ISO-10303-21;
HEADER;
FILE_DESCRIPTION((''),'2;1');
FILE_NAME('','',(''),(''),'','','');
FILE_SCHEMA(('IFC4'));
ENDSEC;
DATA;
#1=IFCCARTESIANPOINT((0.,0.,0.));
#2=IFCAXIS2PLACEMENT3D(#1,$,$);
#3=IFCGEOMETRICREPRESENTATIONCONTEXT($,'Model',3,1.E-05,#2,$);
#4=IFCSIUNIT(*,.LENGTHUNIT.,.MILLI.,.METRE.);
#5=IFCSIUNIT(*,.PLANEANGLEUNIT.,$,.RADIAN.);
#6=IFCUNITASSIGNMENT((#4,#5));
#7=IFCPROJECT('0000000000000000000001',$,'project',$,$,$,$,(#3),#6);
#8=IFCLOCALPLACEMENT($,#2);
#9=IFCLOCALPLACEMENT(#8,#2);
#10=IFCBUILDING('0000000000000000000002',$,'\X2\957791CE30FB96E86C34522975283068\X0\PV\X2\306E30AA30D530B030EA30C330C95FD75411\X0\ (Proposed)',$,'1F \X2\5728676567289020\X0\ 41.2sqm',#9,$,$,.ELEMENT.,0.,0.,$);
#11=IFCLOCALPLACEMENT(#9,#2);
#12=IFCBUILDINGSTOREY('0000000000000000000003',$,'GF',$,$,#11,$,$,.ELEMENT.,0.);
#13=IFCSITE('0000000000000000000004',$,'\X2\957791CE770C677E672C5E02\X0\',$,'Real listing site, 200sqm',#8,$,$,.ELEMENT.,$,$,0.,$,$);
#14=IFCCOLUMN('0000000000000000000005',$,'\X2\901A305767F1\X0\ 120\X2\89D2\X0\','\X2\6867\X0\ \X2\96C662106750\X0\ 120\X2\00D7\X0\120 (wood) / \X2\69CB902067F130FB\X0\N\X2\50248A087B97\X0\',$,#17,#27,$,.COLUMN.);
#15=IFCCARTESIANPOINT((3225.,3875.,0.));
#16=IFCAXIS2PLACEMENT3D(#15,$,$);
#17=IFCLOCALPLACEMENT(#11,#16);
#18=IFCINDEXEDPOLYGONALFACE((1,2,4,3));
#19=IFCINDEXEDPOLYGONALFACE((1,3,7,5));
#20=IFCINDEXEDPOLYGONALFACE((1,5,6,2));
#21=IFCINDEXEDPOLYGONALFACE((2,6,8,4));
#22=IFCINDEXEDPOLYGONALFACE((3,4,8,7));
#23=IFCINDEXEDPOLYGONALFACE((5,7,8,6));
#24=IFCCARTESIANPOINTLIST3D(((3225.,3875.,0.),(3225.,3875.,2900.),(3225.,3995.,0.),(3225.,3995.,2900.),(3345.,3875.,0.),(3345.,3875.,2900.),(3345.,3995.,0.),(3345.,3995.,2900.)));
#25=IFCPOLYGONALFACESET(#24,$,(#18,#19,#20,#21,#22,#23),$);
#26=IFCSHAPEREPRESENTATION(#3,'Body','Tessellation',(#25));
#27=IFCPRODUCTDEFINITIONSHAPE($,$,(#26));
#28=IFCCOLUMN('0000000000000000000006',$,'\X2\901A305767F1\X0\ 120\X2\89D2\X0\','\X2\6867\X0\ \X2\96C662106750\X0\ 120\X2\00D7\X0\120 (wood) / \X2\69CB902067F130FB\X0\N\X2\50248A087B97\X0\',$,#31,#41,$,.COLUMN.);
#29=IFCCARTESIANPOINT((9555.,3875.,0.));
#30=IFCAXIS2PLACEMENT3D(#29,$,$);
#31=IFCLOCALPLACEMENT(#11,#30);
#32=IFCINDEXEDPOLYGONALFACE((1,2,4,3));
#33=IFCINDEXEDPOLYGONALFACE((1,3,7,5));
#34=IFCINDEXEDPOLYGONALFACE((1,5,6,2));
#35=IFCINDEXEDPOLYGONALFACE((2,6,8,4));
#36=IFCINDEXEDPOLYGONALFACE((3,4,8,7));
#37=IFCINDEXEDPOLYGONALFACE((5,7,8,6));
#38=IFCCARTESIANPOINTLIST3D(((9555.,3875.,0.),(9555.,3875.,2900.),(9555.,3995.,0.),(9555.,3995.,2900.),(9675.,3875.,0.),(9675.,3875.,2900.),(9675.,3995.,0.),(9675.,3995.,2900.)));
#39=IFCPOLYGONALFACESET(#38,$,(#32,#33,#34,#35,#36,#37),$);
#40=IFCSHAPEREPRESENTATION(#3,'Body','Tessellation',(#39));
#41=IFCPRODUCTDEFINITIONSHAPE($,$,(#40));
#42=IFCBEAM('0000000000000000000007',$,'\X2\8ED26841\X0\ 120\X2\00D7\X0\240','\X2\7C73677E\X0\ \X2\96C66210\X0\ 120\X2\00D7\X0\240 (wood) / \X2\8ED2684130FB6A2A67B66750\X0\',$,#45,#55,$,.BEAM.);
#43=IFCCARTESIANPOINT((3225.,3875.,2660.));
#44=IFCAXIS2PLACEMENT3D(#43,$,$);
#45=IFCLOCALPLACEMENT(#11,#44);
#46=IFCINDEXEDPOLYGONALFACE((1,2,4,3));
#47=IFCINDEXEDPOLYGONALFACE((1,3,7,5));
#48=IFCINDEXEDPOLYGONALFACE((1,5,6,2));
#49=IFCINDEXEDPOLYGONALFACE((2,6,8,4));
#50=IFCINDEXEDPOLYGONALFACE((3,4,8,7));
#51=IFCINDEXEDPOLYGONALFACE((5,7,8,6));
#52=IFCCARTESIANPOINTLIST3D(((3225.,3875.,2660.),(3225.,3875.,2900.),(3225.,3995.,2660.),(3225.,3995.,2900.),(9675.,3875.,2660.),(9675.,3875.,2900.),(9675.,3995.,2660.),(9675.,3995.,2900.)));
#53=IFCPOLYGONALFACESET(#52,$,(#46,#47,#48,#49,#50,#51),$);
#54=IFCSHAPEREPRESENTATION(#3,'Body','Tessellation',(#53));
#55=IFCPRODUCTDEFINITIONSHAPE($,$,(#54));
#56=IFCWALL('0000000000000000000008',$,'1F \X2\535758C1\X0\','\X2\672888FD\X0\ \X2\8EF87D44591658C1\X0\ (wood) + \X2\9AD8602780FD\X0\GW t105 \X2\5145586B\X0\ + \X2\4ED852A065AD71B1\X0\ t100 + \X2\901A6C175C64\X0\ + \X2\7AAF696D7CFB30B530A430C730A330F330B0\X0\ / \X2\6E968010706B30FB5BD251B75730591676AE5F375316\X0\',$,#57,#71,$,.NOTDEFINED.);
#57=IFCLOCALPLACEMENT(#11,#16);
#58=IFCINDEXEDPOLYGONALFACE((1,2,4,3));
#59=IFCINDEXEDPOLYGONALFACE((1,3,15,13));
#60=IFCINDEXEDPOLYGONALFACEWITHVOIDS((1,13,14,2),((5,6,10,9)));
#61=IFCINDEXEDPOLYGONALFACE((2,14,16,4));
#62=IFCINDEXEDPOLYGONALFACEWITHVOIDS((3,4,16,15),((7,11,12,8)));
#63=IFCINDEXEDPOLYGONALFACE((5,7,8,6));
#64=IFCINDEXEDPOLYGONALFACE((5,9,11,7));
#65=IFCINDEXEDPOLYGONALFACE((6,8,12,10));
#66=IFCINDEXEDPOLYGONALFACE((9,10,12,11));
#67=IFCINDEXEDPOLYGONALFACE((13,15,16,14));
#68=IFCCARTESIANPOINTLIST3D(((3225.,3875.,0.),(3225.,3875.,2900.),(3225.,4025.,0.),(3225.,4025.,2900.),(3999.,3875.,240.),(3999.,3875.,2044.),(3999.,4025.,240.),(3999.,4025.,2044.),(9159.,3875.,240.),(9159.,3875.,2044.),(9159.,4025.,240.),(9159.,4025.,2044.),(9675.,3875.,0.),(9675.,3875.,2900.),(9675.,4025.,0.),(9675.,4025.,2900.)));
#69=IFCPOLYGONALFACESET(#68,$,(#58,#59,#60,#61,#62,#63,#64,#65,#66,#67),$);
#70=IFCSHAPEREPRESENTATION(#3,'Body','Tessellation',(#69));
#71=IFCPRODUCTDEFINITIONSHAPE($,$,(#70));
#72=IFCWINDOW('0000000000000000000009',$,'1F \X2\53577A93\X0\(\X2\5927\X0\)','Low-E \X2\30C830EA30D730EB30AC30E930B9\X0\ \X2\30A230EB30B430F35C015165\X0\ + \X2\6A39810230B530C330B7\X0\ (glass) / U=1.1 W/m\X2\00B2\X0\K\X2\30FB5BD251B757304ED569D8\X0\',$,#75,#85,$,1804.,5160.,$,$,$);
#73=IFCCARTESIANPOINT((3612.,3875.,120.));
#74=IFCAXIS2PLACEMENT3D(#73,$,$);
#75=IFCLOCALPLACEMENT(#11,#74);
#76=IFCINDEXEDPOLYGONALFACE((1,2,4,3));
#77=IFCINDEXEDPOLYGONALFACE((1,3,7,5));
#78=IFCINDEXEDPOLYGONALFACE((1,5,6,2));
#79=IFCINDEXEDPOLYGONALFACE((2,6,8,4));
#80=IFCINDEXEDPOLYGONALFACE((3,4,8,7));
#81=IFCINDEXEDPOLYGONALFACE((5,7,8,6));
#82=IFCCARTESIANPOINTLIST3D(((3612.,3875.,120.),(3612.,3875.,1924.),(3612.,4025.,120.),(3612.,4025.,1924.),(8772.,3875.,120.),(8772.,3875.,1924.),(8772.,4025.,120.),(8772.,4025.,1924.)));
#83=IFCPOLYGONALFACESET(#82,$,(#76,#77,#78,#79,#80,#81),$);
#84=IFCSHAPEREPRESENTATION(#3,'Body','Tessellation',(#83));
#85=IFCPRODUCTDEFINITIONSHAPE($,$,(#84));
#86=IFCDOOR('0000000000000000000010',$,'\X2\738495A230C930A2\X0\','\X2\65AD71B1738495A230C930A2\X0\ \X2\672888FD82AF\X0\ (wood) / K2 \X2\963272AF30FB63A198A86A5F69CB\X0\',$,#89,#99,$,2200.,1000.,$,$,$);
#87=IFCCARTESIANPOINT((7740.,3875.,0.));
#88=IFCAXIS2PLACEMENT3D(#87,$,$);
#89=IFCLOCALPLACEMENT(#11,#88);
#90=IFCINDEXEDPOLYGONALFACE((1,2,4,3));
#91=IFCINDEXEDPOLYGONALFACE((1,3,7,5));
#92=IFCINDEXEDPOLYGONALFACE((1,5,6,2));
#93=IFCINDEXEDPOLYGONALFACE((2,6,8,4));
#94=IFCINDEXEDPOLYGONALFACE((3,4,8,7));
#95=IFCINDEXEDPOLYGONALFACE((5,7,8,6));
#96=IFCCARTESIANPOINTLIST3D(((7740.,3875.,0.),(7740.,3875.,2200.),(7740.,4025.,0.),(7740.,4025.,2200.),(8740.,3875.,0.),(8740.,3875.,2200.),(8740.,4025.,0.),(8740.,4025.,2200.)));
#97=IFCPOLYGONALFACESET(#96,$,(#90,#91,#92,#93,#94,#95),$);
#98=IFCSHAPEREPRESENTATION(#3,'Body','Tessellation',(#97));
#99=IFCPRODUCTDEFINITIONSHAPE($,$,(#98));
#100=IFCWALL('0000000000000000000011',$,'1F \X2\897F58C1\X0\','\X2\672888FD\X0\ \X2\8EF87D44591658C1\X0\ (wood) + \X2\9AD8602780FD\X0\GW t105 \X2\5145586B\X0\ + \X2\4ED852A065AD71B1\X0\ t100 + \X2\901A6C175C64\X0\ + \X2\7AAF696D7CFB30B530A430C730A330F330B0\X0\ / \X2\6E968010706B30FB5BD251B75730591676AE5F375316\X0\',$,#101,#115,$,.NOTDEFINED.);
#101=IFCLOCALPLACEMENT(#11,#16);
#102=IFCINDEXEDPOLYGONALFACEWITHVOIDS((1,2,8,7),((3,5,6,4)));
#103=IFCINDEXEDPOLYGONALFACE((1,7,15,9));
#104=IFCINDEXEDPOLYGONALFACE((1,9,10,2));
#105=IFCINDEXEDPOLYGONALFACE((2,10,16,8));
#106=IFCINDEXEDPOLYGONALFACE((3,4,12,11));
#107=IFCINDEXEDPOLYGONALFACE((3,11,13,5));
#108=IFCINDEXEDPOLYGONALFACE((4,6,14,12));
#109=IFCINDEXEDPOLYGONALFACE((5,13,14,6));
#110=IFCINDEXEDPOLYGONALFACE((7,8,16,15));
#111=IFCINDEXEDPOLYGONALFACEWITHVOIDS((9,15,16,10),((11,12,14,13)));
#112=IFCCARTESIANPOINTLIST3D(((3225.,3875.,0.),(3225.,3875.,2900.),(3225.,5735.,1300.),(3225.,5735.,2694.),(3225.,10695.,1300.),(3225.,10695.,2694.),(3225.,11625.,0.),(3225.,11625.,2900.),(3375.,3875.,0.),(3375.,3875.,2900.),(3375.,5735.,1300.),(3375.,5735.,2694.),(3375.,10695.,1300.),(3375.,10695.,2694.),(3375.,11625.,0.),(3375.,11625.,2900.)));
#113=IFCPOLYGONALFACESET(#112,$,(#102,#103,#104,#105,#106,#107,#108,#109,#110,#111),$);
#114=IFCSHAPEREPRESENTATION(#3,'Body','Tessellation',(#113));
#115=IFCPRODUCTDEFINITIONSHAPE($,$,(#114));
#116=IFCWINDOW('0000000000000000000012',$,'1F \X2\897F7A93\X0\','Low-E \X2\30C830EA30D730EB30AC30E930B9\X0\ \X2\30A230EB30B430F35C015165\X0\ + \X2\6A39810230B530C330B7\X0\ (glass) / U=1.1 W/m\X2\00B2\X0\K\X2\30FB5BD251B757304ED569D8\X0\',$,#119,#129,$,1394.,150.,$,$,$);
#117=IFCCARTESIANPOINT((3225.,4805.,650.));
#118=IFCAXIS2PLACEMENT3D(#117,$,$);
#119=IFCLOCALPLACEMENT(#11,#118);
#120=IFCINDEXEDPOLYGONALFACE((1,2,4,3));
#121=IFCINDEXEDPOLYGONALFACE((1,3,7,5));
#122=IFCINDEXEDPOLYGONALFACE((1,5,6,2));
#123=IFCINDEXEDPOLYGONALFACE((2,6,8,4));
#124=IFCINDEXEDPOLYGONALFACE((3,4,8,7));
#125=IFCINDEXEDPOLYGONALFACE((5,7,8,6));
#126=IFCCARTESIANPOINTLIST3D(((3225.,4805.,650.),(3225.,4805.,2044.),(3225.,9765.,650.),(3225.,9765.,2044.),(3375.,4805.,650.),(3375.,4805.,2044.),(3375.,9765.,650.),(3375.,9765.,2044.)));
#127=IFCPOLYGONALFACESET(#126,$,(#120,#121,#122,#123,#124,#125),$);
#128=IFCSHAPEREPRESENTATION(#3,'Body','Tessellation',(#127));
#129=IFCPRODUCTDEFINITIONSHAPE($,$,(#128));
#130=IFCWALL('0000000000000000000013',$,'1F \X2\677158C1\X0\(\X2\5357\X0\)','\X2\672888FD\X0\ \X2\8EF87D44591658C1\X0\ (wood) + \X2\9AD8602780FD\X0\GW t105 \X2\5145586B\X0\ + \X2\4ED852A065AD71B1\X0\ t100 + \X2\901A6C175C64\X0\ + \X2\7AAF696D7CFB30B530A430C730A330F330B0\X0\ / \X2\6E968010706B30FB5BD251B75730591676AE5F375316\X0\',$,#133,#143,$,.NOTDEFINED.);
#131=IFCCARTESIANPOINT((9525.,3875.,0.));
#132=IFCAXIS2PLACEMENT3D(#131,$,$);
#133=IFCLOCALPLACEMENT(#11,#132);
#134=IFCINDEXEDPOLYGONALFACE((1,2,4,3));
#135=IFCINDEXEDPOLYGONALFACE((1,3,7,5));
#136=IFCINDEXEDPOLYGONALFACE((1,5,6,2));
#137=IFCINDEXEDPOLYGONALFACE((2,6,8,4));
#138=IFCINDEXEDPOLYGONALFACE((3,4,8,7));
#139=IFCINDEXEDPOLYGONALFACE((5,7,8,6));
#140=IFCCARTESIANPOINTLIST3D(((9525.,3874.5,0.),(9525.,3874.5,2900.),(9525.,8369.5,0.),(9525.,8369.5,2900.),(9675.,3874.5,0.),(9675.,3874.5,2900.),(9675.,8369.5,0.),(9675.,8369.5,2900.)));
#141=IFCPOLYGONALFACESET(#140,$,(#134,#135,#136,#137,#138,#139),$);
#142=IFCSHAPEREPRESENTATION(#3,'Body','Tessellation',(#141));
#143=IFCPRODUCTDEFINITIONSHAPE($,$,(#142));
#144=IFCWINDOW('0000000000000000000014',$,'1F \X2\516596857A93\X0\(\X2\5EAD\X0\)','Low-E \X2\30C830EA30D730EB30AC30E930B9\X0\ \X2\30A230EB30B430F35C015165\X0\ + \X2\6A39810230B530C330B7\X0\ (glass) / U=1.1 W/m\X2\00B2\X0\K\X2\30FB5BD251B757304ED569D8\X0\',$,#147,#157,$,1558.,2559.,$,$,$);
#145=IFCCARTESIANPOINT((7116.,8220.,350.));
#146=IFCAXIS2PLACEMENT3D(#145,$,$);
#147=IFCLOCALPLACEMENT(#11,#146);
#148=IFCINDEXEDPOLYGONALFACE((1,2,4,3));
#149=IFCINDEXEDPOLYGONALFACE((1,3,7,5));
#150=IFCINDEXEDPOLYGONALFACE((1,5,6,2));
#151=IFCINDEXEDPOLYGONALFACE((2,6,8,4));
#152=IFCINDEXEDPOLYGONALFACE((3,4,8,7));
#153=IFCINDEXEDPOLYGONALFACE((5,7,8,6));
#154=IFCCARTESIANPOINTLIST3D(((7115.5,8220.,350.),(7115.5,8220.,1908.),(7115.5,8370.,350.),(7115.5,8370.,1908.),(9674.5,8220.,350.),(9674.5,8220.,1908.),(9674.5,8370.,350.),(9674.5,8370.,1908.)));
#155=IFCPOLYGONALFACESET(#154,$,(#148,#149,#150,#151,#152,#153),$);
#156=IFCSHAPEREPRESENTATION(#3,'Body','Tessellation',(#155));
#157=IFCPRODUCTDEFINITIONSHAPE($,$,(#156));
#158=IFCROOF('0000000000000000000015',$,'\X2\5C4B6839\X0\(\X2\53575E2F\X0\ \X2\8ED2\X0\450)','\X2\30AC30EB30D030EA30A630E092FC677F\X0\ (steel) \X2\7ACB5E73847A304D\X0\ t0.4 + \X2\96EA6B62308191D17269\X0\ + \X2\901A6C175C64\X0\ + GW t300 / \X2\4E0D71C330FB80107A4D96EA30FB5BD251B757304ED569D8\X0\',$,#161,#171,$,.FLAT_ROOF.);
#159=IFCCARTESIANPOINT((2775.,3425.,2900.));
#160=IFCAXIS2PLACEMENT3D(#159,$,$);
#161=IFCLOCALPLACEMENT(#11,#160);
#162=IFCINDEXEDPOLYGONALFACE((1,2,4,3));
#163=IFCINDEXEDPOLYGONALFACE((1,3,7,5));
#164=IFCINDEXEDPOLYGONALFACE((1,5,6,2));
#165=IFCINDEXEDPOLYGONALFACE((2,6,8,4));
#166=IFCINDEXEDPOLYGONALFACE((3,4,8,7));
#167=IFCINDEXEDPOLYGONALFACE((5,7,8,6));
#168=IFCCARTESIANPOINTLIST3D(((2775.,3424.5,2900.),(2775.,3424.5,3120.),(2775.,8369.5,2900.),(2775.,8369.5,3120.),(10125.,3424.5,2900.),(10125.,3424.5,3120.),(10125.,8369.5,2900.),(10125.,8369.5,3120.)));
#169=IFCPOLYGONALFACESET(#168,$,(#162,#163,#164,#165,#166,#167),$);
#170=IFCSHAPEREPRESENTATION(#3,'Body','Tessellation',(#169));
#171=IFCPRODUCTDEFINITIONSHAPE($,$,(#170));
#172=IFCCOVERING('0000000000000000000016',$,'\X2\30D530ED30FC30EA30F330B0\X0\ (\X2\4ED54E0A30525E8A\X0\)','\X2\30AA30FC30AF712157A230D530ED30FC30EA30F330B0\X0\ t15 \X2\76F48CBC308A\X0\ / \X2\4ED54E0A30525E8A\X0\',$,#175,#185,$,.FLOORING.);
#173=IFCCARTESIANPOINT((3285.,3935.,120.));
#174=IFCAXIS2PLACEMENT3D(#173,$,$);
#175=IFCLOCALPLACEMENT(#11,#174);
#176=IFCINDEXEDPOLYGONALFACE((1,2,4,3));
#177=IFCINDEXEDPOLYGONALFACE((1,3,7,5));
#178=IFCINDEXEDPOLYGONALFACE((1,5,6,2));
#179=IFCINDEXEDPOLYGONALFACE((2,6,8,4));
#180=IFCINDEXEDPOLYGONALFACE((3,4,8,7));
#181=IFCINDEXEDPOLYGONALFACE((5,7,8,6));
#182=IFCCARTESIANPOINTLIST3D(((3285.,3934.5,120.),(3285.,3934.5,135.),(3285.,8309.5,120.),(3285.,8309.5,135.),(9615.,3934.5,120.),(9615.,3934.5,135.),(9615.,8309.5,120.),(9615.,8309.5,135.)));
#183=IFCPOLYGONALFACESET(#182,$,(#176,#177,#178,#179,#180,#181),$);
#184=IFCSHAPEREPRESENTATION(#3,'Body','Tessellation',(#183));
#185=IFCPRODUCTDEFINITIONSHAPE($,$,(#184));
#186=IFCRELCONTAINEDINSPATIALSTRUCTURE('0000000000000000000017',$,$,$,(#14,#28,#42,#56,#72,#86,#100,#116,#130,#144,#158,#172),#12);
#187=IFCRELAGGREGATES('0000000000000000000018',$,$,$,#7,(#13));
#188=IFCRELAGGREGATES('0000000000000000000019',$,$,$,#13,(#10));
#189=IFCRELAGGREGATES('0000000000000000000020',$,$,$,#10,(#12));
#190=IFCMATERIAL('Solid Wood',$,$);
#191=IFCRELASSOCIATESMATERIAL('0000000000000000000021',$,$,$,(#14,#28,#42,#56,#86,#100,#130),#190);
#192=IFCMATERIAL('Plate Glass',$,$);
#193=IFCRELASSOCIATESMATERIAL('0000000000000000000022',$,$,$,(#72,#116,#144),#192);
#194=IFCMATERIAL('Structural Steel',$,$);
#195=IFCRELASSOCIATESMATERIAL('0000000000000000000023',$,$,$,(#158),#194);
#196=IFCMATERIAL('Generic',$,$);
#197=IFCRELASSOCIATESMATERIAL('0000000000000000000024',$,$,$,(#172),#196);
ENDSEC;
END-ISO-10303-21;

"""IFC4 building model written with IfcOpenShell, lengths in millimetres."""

from ifc_helpers import new_model, si_unit, frame, frame_2d, origin, place, context, project, spatial, rectangle, extrude, material, element, fill, save


model = new_model("IFC4")

# Units and contexts
model_context = context("Model", 3, precision=1e-05, world=origin())
ifc_project = project(units=[si_unit("LENGTHUNIT", "METRE", prefix="MILLI"), si_unit("PLANEANGLEUNIT", "RADIAN")], contexts=[model_context])

# Site, building, storey
site_placement = place(None, origin())
site = spatial("IfcSite", under=ifc_project, at=site_placement, Name="長野県松本市", ObjectType="Real listing site, 200sqm", CompositionType="ELEMENT", RefElevation=0.0)
building_placement = place(site_placement, origin())
building = spatial("IfcBuilding", under=site, at=building_placement, Name="長野・雨水利用とPVのオフグリッド志向 (Proposed)", ObjectType="1F 在来木造 41.2sqm", CompositionType="ELEMENT", ElevationOfRefHeight=0.0, ElevationOfTerrain=0.0)
storey_placement = place(building_placement, origin())
storey = spatial("IfcBuildingStorey", under=building, at=storey_placement, Name="GF", CompositionType="ELEMENT", Elevation=0.0)

# Columns
ifc_material_1 = material(Name="Solid Wood")
column_1_placement = place(storey_placement, frame((3225.0, 3875.0, 0.0)))
element("IfcColumn", 1, at=column_1_placement, inside=storey, material=ifc_material_1, Name="通し柱 120角", Description="桧 集成材 120×120 (wood) / 構造柱・N値計算", PredefinedType="COLUMN", context=model_context, shape_type="SweptSolid", body=[
    extrude(rectangle(XDim=120.0, YDim=120.0, at=frame_2d((60.0, 60.0))), frame((3225.0, 3875.0, 0.0)), (0.0, 0.0, 1.0), 2900.0),
])
column_2_placement = place(storey_placement, frame((9555.0, 3875.0, 0.0)))
element("IfcColumn", 2, at=column_2_placement, inside=storey, material=ifc_material_1, Name="通し柱 120角", Description="桧 集成材 120×120 (wood) / 構造柱・N値計算", PredefinedType="COLUMN", context=model_context, shape_type="SweptSolid", body=[
    extrude(rectangle(XDim=120.0, YDim=120.0, at=frame_2d((60.0, 60.0))), frame((9555.0, 3875.0, 0.0)), (0.0, 0.0, 1.0), 2900.0),
])

# Beam
beam_1_placement = place(storey_placement, frame((3225.0, 3875.0, 2660.0)))
element("IfcBeam", 3, at=beam_1_placement, inside=storey, material=ifc_material_1, Name="軒桁 120×240", Description="米松 集成 120×240 (wood) / 軒桁・横架材", PredefinedType="BEAM", context=model_context, shape_type="SweptSolid", body=[
    extrude(rectangle(XDim=6450.0, YDim=120.0, at=frame_2d((3225.0, 60.0))), frame((3225.0, 3875.0, 2660.0)), (0.0, 0.0, 1.0), 240.0),
])

# Wall, openings, window, door
wall_1_placement = place(storey_placement, frame((3225.0, 3875.0, 0.0)))
wall_1 = element("IfcWall", 4, at=wall_1_placement, inside=storey, material=ifc_material_1, Name="1F 南壁", Description="木製 軸組外壁 (wood) + 高性能GW t105 充填 + 付加断熱 t100 + 通気層 + 窯業系サイディング / 準耐火・寒冷地外皮強化", PredefinedType="NOTDEFINED", context=model_context, shape_type="SweptSolid", body=[
    extrude(rectangle(XDim=6450.0, YDim=150.0, at=frame_2d((3225.0, 75.0))), frame((3225.0, 3875.0, 0.0)), (0.0, 0.0, 1.0), 2900.0),
])
opening_1_placement = place(storey_placement, frame((3612.0, 3875.0, 120.0)))
opening_1 = element("IfcOpeningElement", 5, at=opening_1_placement, cuts=wall_1, PredefinedType="NOTDEFINED", context=model_context, shape_type="SweptSolid", body=[
    extrude(rectangle(XDim=5160.0, YDim=150.0, at=frame_2d((2580.0, 75.0))), frame((3612.0, 3875.0, 120.0)), (0.0, 0.0, 1.0), 1804.0),
])
opening_2_placement = place(storey_placement, frame((7740.0, 3875.0, 0.0)))
opening_2 = element("IfcOpeningElement", 6, at=opening_2_placement, cuts=wall_1, PredefinedType="NOTDEFINED", context=model_context, shape_type="SweptSolid", body=[
    extrude(rectangle(XDim=1000.0, YDim=150.0, at=frame_2d((500.0, 75.0))), frame((7740.0, 3875.0, 0.0)), (0.0, 0.0, 1.0), 2200.0),
])
ifc_material_2 = material(Name="Plate Glass")
window_1_placement = place(storey_placement, frame((3612.0, 3875.0, 120.0)))
window_1 = element("IfcWindow", 7, at=window_1_placement, inside=storey, material=ifc_material_2, Name="1F 南窓(大)", Description="Low-E トリプルガラス アルゴン封入 + 樹脂サッシ (glass) / U=1.1 W/m²K・寒冷地仕様", OverallHeight=1804.0, OverallWidth=5160.0, context=model_context, shape_type="SweptSolid", body=[
    extrude(rectangle(XDim=5160.0, YDim=150.0, at=frame_2d((2580.0, 75.0))), frame((3612.0, 3875.0, 120.0)), (0.0, 0.0, 1.0), 1804.0),
])
fill(opening_1, window_1)
door_1_placement = place(storey_placement, frame((7740.0, 3875.0, 0.0)))
door_1 = element("IfcDoor", 8, at=door_1_placement, inside=storey, material=ifc_material_1, Name="玄関ドア", Description="断熱玄関ドア 木製芯 (wood) / K2 防犯・採風機構", OverallHeight=2200.0, OverallWidth=1000.0, context=model_context, shape_type="SweptSolid", body=[
    extrude(rectangle(XDim=1000.0, YDim=150.0, at=frame_2d((500.0, 75.0))), frame((7740.0, 3875.0, 0.0)), (0.0, 0.0, 1.0), 2200.0),
])
fill(opening_2, door_1)

# Walls, openings, windows
wall_2_placement = place(storey_placement, frame((3225.0, 3875.0, 0.0)))
wall_2 = element("IfcWall", 9, at=wall_2_placement, inside=storey, material=ifc_material_1, Name="1F 西壁", Description="木製 軸組外壁 (wood) + 高性能GW t105 充填 + 付加断熱 t100 + 通気層 + 窯業系サイディング / 準耐火・寒冷地外皮強化", PredefinedType="NOTDEFINED", context=model_context, shape_type="SweptSolid", body=[
    extrude(rectangle(XDim=150.0, YDim=7750.0, at=frame_2d((75.0, 3875.0))), frame((3225.0, 3875.0, 0.0)), (0.0, 0.0, 1.0), 2900.0),
])
opening_3_placement = place(storey_placement, frame((3225.0, 4805.0, 650.0)))
opening_3 = element("IfcOpeningElement", 10, at=opening_3_placement, cuts=wall_2, PredefinedType="NOTDEFINED", context=model_context, shape_type="SweptSolid", body=[
    extrude(rectangle(XDim=150.0, YDim=4960.0, at=frame_2d((75.0, 2480.0))), frame((3225.0, 4805.0, 650.0)), (0.0, 0.0, 1.0), 1394.0),
])
window_2_placement = place(storey_placement, frame((3225.0, 4805.0, 650.0)))
window_2 = element("IfcWindow", 11, at=window_2_placement, inside=storey, material=ifc_material_2, Name="1F 西窓", Description="Low-E トリプルガラス アルゴン封入 + 樹脂サッシ (glass) / U=1.1 W/m²K・寒冷地仕様", OverallHeight=1394.0, OverallWidth=150.0, context=model_context, shape_type="SweptSolid", body=[
    extrude(rectangle(XDim=150.0, YDim=4960.0, at=frame_2d((75.0, 2480.0))), frame((3225.0, 4805.0, 650.0)), (0.0, 0.0, 1.0), 1394.0),
])
fill(opening_3, window_2)
wall_3_placement = place(storey_placement, frame((9525.0, 3875.0, 0.0)))
wall_3 = element("IfcWall", 12, at=wall_3_placement, inside=storey, material=ifc_material_1, Name="1F 東壁(南)", Description="木製 軸組外壁 (wood) + 高性能GW t105 充填 + 付加断熱 t100 + 通気層 + 窯業系サイディング / 準耐火・寒冷地外皮強化", PredefinedType="NOTDEFINED", context=model_context, shape_type="SweptSolid", body=[
    extrude(rectangle(XDim=150.0, YDim=4495.0, at=frame_2d((75.0, 2247.0))), frame((9525.0, 3875.0, 0.0)), (0.0, 0.0, 1.0), 2900.0),
])
opening_4_placement = place(storey_placement, frame((7116.0, 8220.0, 350.0)))
opening_4 = element("IfcOpeningElement", 13, at=opening_4_placement, cuts=wall_3, PredefinedType="NOTDEFINED", context=model_context, shape_type="SweptSolid", body=[
    extrude(rectangle(XDim=2559.0, YDim=150.0, at=frame_2d((1279.0, 75.0))), frame((7116.0, 8220.0, 350.0)), (0.0, 0.0, 1.0), 1558.0),
])
window_3_placement = place(storey_placement, frame((7116.0, 8220.0, 350.0)))
window_3 = element("IfcWindow", 14, at=window_3_placement, inside=storey, material=ifc_material_2, Name="1F 入隅窓(庭)", Description="Low-E トリプルガラス アルゴン封入 + 樹脂サッシ (glass) / U=1.1 W/m²K・寒冷地仕様", OverallHeight=1558.0, OverallWidth=2559.0, context=model_context, shape_type="SweptSolid", body=[
    extrude(rectangle(XDim=2559.0, YDim=150.0, at=frame_2d((1279.0, 75.0))), frame((7116.0, 8220.0, 350.0)), (0.0, 0.0, 1.0), 1558.0),
])
fill(opening_4, window_3)

# Roof
ifc_material_3 = material(Name="Structural Steel")
roof_placement = place(storey_placement, frame((2775.0, 3425.0, 2900.0)))
element("IfcRoof", 15, at=roof_placement, inside=storey, material=ifc_material_3, Name="屋根(南帯 軒450)", Description="ガルバリウム鋼板 (steel) 立平葺き t0.4 + 雪止め金物 + 通気層 + GW t300 / 不燃・耐積雪・寒冷地仕様", PredefinedType="FLAT_ROOF", context=model_context, shape_type="SweptSolid", body=[
    extrude(rectangle(XDim=7350.0, YDim=4945.0, at=frame_2d((3675.0, 2472.0))), frame((2775.0, 3425.0, 2900.0)), (0.0, 0.0, 1.0), 220.0),
])

# Covering
ifc_material_4 = material(Name="Generic")
covering_1_placement = place(storey_placement, frame((3285.0, 3935.0, 120.0)))
element("IfcCovering", 16, at=covering_1_placement, inside=storey, material=ifc_material_4, Name="フローリング (仕上げ床)", Description="オーク無垢フローリング t15 直貼り / 仕上げ床", PredefinedType="FLOORING", context=model_context, shape_type="SweptSolid", body=[
    extrude(rectangle(XDim=6330.0, YDim=4375.0, at=frame_2d((3165.0, 2187.0))), frame((3285.0, 3935.0, 120.0)), (0.0, 0.0, 1.0), 15.0),
])

save(model, "model.ifc")
